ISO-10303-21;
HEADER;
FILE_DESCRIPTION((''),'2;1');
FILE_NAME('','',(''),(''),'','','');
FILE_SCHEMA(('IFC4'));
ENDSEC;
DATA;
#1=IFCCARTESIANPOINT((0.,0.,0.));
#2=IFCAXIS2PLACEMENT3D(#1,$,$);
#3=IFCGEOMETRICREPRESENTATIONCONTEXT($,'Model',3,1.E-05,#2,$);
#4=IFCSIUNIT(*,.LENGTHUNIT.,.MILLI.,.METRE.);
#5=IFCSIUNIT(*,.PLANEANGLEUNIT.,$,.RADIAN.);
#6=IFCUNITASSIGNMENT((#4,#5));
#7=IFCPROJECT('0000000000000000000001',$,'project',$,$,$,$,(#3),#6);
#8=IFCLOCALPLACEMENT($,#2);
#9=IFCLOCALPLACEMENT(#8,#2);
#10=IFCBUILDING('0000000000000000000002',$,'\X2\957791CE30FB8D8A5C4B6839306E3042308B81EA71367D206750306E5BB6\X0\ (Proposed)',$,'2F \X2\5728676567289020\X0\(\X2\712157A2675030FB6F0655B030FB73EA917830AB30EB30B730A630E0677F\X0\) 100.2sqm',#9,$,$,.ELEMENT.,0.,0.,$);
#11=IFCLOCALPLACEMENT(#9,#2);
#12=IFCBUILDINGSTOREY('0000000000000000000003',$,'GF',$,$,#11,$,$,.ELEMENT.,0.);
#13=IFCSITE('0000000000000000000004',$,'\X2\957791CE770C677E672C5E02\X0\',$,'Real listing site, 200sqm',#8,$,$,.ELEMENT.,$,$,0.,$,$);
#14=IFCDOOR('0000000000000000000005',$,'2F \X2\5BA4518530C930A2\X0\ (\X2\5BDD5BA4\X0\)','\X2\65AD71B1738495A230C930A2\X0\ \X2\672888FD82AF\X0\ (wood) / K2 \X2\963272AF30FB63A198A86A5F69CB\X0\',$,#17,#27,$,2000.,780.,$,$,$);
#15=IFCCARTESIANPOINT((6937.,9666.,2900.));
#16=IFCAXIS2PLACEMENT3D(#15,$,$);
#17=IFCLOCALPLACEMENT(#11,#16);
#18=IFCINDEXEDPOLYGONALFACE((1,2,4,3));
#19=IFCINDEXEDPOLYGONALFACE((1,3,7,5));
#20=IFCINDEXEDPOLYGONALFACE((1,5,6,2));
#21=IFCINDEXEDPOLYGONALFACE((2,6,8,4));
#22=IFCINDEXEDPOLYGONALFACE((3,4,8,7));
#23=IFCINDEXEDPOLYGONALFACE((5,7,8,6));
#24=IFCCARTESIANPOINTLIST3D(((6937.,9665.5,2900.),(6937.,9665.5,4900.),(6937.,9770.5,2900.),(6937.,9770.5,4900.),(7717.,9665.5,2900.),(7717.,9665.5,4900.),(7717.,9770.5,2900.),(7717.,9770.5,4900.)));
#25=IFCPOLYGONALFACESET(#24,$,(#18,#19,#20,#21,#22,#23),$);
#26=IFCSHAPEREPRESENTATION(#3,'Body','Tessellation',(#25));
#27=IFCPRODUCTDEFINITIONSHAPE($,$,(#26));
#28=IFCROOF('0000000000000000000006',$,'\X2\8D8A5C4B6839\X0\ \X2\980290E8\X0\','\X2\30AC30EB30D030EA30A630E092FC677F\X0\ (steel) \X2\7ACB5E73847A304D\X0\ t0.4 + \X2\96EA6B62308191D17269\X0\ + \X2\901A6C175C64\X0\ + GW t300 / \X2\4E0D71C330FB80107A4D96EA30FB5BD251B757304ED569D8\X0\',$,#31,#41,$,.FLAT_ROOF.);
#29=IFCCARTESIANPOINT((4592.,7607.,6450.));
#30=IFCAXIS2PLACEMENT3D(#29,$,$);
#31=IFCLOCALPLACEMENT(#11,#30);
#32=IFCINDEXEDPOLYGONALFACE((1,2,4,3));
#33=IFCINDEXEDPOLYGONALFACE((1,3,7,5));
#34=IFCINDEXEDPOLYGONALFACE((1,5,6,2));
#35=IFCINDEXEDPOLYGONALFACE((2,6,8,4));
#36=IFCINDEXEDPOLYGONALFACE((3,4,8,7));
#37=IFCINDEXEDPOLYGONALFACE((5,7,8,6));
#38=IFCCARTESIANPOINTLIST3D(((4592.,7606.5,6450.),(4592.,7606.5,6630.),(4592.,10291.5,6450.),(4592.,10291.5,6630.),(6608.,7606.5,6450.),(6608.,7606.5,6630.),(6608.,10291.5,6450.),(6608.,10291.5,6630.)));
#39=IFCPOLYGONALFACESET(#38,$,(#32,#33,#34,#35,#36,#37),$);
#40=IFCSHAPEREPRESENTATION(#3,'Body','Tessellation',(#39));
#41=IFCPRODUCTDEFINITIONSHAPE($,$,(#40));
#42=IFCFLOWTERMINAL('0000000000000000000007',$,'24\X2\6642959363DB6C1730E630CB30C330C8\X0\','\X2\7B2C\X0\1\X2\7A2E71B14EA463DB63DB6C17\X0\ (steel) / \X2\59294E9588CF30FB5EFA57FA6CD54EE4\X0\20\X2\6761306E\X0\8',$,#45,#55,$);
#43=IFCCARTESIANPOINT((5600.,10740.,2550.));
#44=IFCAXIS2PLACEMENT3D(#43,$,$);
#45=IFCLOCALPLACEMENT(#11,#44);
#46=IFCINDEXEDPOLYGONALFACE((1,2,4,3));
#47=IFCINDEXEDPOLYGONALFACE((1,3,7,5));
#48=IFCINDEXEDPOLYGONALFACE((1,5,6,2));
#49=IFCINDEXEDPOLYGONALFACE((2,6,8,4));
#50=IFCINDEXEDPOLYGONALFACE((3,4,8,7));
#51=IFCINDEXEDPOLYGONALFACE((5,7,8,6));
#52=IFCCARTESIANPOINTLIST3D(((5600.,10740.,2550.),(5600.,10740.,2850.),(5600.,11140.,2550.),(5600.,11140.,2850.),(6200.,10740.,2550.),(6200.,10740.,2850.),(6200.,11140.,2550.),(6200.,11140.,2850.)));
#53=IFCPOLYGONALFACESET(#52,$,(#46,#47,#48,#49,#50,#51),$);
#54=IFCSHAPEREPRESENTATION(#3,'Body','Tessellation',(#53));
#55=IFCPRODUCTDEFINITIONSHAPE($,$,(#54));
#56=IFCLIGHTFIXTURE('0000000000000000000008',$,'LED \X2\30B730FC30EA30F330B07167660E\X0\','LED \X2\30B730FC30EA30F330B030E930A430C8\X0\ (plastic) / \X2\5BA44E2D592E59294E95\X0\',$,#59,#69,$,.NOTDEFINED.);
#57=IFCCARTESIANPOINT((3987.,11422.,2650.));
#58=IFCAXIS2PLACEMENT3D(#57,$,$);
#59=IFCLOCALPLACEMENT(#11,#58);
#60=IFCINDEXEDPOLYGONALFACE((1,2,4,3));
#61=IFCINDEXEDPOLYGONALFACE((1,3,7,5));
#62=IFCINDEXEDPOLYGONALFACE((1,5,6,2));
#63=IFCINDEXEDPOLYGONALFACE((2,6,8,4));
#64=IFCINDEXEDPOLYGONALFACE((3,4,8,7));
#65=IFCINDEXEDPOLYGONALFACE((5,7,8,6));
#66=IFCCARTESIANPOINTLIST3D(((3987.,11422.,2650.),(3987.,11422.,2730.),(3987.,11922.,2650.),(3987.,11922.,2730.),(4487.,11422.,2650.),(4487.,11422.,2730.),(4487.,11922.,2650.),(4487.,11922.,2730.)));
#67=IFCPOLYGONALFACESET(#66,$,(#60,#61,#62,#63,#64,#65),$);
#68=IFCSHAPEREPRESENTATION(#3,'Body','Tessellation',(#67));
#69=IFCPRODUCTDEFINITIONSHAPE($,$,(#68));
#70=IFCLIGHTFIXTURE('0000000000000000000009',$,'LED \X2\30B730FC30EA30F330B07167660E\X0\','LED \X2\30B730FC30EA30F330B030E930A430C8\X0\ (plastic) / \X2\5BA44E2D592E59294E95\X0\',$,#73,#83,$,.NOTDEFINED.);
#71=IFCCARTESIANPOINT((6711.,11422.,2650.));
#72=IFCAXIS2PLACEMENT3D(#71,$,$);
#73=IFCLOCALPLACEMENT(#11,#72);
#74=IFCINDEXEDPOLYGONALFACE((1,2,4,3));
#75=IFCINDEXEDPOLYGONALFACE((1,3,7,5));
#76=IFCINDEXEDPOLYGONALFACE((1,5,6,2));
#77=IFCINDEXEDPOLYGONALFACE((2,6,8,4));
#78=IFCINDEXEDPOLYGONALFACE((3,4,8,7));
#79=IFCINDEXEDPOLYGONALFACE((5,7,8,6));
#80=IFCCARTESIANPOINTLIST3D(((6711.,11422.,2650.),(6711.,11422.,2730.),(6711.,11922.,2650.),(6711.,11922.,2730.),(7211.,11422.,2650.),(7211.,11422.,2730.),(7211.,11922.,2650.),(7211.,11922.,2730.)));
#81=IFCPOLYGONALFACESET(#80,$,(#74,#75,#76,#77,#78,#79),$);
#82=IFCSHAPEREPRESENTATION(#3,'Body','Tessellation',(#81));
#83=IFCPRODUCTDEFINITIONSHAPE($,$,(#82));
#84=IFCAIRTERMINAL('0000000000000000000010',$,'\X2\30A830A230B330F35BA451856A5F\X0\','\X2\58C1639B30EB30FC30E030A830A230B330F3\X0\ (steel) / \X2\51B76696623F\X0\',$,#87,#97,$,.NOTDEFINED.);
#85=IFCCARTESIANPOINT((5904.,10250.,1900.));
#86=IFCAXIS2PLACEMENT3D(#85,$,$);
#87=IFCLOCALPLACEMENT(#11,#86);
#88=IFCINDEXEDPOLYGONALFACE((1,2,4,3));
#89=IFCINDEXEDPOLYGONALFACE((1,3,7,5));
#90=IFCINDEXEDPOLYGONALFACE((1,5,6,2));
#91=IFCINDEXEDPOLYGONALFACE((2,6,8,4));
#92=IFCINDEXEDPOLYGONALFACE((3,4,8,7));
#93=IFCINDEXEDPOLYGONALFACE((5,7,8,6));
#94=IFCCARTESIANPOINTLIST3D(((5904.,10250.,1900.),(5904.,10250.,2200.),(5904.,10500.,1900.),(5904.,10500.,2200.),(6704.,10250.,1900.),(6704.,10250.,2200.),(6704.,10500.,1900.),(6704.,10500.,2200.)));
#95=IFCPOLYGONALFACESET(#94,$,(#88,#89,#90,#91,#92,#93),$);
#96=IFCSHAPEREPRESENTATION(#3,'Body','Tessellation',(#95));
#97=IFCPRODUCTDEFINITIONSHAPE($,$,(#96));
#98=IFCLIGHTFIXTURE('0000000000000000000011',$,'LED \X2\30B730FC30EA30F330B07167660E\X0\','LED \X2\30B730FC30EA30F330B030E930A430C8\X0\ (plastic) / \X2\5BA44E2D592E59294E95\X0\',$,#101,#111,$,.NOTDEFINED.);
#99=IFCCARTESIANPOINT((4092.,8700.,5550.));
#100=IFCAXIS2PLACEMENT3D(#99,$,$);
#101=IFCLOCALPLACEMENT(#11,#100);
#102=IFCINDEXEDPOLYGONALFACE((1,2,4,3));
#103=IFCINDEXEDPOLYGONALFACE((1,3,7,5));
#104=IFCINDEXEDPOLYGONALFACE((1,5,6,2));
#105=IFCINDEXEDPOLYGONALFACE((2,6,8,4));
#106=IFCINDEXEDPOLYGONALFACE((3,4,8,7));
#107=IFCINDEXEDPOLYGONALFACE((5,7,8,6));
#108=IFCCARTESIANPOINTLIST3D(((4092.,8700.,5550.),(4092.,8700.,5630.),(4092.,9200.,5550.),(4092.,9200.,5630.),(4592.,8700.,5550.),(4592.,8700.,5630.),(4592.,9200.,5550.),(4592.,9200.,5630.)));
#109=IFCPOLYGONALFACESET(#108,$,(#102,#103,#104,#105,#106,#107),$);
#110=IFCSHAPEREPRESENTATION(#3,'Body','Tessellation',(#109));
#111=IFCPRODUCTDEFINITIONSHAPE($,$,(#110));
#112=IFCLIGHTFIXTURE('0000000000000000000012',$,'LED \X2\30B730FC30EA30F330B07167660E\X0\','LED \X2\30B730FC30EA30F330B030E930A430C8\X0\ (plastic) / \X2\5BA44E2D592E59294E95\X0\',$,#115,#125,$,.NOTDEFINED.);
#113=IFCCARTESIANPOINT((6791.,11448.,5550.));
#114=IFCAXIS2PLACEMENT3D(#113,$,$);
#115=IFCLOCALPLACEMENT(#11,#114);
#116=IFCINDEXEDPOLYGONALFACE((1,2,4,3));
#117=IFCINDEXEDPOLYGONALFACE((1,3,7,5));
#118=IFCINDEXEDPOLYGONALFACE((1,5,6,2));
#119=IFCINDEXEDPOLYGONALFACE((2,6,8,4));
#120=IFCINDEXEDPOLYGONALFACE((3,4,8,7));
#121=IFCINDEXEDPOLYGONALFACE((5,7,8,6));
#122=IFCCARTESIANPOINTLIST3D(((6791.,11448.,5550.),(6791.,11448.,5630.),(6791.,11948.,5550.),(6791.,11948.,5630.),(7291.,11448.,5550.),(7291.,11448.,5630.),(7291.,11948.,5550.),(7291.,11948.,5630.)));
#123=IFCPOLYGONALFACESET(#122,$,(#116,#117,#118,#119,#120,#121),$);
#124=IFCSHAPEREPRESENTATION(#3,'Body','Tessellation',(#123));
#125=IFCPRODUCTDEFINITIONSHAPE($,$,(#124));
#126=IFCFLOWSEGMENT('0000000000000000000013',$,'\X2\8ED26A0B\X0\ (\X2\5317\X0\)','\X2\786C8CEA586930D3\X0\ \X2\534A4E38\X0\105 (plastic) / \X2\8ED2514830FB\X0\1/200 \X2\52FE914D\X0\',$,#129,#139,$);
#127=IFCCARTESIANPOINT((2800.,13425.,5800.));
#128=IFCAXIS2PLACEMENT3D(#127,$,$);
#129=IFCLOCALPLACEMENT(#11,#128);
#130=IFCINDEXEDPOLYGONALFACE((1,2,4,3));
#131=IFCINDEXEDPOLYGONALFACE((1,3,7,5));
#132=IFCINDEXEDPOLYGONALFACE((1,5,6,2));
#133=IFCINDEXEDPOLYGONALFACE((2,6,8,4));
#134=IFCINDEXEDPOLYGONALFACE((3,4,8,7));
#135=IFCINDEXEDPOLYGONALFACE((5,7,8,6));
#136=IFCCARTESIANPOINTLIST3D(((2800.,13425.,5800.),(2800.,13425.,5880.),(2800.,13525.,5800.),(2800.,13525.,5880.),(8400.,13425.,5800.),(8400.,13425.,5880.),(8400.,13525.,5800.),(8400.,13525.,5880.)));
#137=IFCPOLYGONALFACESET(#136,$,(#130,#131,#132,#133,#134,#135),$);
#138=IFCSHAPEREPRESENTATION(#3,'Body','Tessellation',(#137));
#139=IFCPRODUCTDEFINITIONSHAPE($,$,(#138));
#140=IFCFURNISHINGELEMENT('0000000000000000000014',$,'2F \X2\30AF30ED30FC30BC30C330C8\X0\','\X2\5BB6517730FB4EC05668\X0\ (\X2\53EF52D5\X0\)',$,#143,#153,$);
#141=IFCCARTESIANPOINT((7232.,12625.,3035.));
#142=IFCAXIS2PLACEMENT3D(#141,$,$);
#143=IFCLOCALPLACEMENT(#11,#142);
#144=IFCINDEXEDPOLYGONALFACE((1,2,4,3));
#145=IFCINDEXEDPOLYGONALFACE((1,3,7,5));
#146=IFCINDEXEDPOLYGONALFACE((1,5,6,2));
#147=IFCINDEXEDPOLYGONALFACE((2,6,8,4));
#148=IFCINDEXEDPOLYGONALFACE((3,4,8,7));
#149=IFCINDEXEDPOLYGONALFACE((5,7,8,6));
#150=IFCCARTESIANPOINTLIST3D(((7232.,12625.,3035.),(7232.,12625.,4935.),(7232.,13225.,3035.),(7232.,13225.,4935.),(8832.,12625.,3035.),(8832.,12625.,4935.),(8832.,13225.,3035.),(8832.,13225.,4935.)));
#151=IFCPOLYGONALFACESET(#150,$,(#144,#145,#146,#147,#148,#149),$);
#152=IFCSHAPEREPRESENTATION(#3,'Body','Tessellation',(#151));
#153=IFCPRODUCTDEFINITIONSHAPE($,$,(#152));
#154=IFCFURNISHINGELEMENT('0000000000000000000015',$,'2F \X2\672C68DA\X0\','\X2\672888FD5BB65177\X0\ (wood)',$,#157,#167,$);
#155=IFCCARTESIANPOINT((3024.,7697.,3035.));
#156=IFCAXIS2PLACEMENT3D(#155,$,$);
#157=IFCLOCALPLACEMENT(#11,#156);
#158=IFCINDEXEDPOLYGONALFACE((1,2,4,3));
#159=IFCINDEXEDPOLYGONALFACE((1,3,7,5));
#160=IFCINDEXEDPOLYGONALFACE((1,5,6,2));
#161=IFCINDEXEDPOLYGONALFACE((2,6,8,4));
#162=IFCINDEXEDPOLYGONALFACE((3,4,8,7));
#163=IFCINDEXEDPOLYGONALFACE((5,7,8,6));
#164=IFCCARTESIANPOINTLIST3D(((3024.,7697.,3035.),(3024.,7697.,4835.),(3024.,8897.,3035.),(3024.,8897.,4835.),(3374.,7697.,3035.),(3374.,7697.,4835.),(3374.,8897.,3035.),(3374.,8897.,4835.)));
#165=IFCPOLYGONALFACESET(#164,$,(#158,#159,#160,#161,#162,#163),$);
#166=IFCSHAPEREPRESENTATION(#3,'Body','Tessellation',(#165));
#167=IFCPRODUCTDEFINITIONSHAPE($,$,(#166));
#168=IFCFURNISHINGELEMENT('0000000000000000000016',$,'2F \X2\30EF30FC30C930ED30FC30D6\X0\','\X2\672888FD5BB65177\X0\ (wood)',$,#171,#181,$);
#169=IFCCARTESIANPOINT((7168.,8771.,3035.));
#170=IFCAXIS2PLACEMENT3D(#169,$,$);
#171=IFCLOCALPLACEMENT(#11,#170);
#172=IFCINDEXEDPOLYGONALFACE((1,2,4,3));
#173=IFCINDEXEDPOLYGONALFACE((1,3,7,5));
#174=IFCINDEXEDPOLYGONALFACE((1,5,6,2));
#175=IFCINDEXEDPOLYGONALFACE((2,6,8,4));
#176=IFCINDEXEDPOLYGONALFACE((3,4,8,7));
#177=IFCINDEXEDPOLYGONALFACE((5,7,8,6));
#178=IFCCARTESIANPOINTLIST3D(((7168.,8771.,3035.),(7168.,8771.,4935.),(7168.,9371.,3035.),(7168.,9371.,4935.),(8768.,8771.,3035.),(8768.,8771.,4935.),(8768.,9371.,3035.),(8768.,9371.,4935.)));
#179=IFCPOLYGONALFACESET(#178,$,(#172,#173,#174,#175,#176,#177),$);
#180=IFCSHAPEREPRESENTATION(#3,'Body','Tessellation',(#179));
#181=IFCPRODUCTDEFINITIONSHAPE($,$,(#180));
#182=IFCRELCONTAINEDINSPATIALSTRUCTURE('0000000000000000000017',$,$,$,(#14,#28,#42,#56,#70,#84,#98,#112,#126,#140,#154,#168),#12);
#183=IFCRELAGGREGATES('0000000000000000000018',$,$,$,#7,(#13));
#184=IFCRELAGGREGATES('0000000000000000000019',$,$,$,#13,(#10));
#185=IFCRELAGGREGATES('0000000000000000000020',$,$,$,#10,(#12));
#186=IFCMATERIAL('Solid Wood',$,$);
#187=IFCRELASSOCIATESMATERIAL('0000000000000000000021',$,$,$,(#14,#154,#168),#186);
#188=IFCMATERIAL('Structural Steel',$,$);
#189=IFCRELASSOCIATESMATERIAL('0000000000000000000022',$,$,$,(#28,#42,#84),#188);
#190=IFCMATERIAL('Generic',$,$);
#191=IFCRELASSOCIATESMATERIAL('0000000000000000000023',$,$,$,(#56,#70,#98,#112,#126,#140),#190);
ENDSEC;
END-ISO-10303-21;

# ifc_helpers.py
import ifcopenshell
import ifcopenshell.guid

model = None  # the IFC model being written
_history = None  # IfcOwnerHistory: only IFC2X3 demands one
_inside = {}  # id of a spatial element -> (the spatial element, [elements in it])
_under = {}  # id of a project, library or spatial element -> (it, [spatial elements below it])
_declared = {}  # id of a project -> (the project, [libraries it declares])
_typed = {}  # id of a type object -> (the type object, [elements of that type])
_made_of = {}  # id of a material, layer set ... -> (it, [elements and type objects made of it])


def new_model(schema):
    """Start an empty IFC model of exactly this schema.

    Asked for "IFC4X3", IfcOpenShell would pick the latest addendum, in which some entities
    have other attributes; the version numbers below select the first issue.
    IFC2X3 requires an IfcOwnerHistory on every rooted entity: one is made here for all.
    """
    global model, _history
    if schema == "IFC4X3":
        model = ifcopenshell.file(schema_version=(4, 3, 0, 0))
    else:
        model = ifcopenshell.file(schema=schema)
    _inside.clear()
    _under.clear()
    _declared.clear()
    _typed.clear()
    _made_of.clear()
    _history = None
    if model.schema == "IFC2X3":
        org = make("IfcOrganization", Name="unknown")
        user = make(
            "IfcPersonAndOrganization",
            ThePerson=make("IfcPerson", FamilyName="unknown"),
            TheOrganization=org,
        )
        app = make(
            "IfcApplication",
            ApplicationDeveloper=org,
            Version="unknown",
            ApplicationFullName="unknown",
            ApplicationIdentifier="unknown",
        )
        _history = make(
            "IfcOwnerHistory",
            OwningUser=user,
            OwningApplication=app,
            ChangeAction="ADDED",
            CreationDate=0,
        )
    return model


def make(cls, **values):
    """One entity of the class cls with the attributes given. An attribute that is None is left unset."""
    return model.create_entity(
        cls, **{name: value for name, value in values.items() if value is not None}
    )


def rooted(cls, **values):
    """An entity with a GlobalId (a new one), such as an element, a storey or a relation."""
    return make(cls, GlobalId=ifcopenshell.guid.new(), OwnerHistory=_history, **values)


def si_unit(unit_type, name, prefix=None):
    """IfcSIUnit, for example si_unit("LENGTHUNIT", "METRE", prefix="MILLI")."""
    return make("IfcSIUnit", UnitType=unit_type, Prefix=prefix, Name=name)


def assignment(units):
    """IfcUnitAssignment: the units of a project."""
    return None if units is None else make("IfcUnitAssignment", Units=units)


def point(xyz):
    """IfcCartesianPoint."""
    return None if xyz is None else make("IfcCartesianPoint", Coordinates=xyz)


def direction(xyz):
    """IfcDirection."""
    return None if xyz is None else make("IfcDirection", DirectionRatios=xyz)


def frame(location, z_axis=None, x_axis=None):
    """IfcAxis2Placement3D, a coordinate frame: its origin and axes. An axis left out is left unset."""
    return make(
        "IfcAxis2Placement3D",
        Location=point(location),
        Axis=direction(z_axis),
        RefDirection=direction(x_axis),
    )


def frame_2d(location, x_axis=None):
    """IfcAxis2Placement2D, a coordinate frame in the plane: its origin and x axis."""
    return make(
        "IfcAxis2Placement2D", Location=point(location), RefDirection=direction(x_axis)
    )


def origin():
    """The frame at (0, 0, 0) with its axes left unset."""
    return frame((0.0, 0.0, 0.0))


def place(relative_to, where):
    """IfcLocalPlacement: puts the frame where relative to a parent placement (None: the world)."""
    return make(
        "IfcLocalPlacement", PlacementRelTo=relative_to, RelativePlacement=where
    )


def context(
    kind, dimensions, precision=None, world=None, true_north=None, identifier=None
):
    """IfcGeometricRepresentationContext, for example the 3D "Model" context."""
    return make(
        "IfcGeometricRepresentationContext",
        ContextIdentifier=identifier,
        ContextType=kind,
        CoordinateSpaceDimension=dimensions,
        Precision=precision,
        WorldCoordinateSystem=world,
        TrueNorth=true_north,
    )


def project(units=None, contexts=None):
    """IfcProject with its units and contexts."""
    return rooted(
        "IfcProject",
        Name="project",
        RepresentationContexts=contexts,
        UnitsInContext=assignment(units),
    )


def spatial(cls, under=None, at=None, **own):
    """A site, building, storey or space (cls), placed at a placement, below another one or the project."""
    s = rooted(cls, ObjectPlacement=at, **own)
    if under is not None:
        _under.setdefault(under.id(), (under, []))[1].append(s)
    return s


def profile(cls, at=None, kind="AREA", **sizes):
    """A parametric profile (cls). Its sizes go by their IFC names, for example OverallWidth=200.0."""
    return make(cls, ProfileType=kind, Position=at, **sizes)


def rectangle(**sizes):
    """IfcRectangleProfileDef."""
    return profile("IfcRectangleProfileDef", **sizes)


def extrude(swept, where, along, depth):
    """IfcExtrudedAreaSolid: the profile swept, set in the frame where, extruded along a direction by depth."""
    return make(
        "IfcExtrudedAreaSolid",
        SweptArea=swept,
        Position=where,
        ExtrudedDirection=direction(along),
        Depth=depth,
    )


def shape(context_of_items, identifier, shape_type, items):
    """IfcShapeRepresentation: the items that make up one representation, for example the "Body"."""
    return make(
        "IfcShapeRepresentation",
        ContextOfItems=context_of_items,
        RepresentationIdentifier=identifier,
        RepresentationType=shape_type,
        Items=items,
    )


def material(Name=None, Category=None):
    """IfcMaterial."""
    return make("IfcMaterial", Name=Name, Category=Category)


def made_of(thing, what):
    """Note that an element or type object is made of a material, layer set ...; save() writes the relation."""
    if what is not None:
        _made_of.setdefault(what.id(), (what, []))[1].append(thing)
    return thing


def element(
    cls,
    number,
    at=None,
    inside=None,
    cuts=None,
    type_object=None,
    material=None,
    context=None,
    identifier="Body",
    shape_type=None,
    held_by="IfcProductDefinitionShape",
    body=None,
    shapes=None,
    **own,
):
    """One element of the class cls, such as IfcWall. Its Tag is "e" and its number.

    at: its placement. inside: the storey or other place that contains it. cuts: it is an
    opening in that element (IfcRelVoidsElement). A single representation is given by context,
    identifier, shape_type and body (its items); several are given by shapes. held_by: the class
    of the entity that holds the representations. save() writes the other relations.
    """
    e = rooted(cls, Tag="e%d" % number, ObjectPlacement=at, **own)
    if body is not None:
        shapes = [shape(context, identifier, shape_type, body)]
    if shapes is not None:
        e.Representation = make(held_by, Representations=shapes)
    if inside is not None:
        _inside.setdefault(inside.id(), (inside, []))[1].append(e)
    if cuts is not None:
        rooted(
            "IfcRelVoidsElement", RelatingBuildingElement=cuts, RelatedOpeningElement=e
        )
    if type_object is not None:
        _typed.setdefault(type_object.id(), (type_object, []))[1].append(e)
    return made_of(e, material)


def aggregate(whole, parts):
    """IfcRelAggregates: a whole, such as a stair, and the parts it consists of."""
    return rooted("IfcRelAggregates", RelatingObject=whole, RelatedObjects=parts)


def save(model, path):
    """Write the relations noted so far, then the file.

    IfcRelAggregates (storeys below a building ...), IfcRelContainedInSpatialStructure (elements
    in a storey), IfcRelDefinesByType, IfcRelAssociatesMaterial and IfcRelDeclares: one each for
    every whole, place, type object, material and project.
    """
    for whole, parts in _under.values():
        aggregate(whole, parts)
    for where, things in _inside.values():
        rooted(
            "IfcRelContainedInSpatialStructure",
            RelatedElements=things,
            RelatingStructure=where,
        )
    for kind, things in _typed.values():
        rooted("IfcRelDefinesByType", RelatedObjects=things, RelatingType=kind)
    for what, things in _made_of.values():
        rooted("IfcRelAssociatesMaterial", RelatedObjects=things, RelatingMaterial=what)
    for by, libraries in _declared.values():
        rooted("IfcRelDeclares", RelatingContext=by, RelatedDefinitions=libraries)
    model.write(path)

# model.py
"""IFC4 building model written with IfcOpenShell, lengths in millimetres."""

from ifc_helpers import new_model, si_unit, frame, frame_2d, origin, place, context, project, spatial, rectangle, extrude, material, element, save


model = new_model("IFC4")

# Units and contexts
model_context = context("Model", 3, precision=1e-05, world=origin())
ifc_project = project(units=[si_unit("LENGTHUNIT", "METRE", prefix="MILLI"), si_unit("PLANEANGLEUNIT", "RADIAN")], contexts=[model_context])

# Site, building, storey
site_placement = place(None, origin())
site = spatial("IfcSite", under=ifc_project, at=site_placement, Name="長野県松本市", ObjectType="Real listing site, 200sqm", CompositionType="ELEMENT", RefElevation=0.0)
building_placement = place(site_placement, origin())
building = spatial("IfcBuilding", under=site, at=building_placement, Name="長野・越屋根のある自然素材の家 (Proposed)", ObjectType="2F 在来木造(無垢材・漆喰・珪酸カルシウム板) 100.2sqm", CompositionType="ELEMENT", ElevationOfRefHeight=0.0, ElevationOfTerrain=0.0)
storey_placement = place(building_placement, origin())
storey = spatial("IfcBuildingStorey", under=building, at=storey_placement, Name="GF", CompositionType="ELEMENT", Elevation=0.0)

# Shared definitions
ifc_material_1 = material(Name="Solid Wood")

# Door
door_placement = place(storey_placement, frame((6937.0, 9666.0, 2900.0)))
element("IfcDoor", 1, at=door_placement, inside=storey, material=ifc_material_1, Name="2F 室内ドア (寝室)", Description="断熱玄関ドア 木製芯 (wood) / K2 防犯・採風機構", OverallHeight=2000.0, OverallWidth=780.0, context=model_context, shape_type="SweptSolid", body=[
    extrude(rectangle(XDim=780.0, YDim=105.0, at=frame_2d((390.0, 52.0))), frame((6937.0, 9666.0, 2900.0)), (0.0, 0.0, 1.0), 2000.0),
])

# Roof
ifc_material_2 = material(Name="Structural Steel")
roof_placement = place(storey_placement, frame((4592.0, 7607.0, 6450.0)))
element("IfcRoof", 2, at=roof_placement, inside=storey, material=ifc_material_2, Name="越屋根 頂部", Description="ガルバリウム鋼板 (steel) 立平葺き t0.4 + 雪止め金物 + 通気層 + GW t300 / 不燃・耐積雪・寒冷地仕様", PredefinedType="FLAT_ROOF", context=model_context, shape_type="SweptSolid", body=[
    extrude(rectangle(XDim=2016.0, YDim=2685.0, at=frame_2d((1008.0, 1342.0))), frame((4592.0, 7607.0, 6450.0)), (0.0, 0.0, 1.0), 180.0),
])

# Flow terminal
flow_terminal_placement = place(storey_placement, frame((5600.0, 10740.0, 2550.0)))
element("IfcFlowTerminal", 3, at=flow_terminal_placement, inside=storey, material=ifc_material_2, Name="24時間換気ユニット", Description="第1種熱交換換気 (steel) / 天井裏・建基法令20条の8", context=model_context, shape_type="SweptSolid", body=[
    extrude(rectangle(XDim=600.0, YDim=400.0, at=frame_2d((300.0, 200.0))), frame((5600.0, 10740.0, 2550.0)), (0.0, 0.0, 1.0), 300.0),
])

# Light fixtures
ifc_material_3 = material(Name="Generic")
light_fixture_1_placement = place(storey_placement, frame((3987.0, 11422.0, 2650.0)))
element("IfcLightFixture", 4, at=light_fixture_1_placement, inside=storey, material=ifc_material_3, Name="LED シーリング照明", Description="LED シーリングライト (plastic) / 室中央天井", PredefinedType="NOTDEFINED", context=model_context, shape_type="SweptSolid", body=[
    extrude(rectangle(XDim=500.0, YDim=500.0, at=frame_2d((250.0, 250.0))), frame((3987.0, 11422.0, 2650.0)), (0.0, 0.0, 1.0), 80.0),
])
light_fixture_2_placement = place(storey_placement, frame((6711.0, 11422.0, 2650.0)))
element("IfcLightFixture", 5, at=light_fixture_2_placement, inside=storey, material=ifc_material_3, Name="LED シーリング照明", Description="LED シーリングライト (plastic) / 室中央天井", PredefinedType="NOTDEFINED", context=model_context, shape_type="SweptSolid", body=[
    extrude(rectangle(XDim=500.0, YDim=500.0, at=frame_2d((250.0, 250.0))), frame((6711.0, 11422.0, 2650.0)), (0.0, 0.0, 1.0), 80.0),
])

# Air terminal
air_terminal_placement = place(storey_placement, frame((5904.0, 10250.0, 1900.0)))
element("IfcAirTerminal", 6, at=air_terminal_placement, inside=storey, material=ifc_material_2, Name="エアコン室内機", Description="壁掛ルームエアコン (steel) / 冷暖房", PredefinedType="NOTDEFINED", context=model_context, shape_type="SweptSolid", body=[
    extrude(rectangle(XDim=800.0, YDim=250.0, at=frame_2d((400.0, 125.0))), frame((5904.0, 10250.0, 1900.0)), (0.0, 0.0, 1.0), 300.0),
])

# Light fixtures
light_fixture_3_placement = place(storey_placement, frame((4092.0, 8700.0, 5550.0)))
element("IfcLightFixture", 7, at=light_fixture_3_placement, inside=storey, material=ifc_material_3, Name="LED シーリング照明", Description="LED シーリングライト (plastic) / 室中央天井", PredefinedType="NOTDEFINED", context=model_context, shape_type="SweptSolid", body=[
    extrude(rectangle(XDim=500.0, YDim=500.0, at=frame_2d((250.0, 250.0))), frame((4092.0, 8700.0, 5550.0)), (0.0, 0.0, 1.0), 80.0),
])
light_fixture_4_placement = place(storey_placement, frame((6791.0, 11448.0, 5550.0)))
element("IfcLightFixture", 8, at=light_fixture_4_placement, inside=storey, material=ifc_material_3, Name="LED シーリング照明", Description="LED シーリングライト (plastic) / 室中央天井", PredefinedType="NOTDEFINED", context=model_context, shape_type="SweptSolid", body=[
    extrude(rectangle(XDim=500.0, YDim=500.0, at=frame_2d((250.0, 250.0))), frame((6791.0, 11448.0, 5550.0)), (0.0, 0.0, 1.0), 80.0),
])

# Flow segment
flow_segment_placement = place(storey_placement, frame((2800.0, 13425.0, 5800.0)))
element("IfcFlowSegment", 9, at=flow_segment_placement, inside=storey, material=ifc_material_3, Name="軒樋 (北)", Description="硬質塩ビ 半丸105 (plastic) / 軒先・1/200 勾配", context=model_context, shape_type="SweptSolid", body=[
    extrude(rectangle(XDim=5600.0, YDim=100.0, at=frame_2d((2800.0, 50.0))), frame((2800.0, 13425.0, 5800.0)), (0.0, 0.0, 1.0), 80.0),
])

# Furnishing elements
furnishing_1_placement = place(storey_placement, frame((7232.0, 12625.0, 3035.0)))
element("IfcFurnishingElement", 10, at=furnishing_1_placement, inside=storey, material=ifc_material_3, Name="2F クローゼット", Description="家具・什器 (可動)", context=model_context, shape_type="SweptSolid", body=[
    extrude(rectangle(XDim=1600.0, YDim=600.0, at=frame_2d((800.0, 300.0))), frame((7232.0, 12625.0, 3035.0)), (0.0, 0.0, 1.0), 1900.0),
])
furnishing_2_placement = place(storey_placement, frame((3024.0, 7697.0, 3035.0)))
element("IfcFurnishingElement", 11, at=furnishing_2_placement, inside=storey, material=ifc_material_1, Name="2F 本棚", Description="木製家具 (wood)", context=model_context, shape_type="SweptSolid", body=[
    extrude(rectangle(XDim=350.0, YDim=1200.0, at=frame_2d((175.0, 600.0))), frame((3024.0, 7697.0, 3035.0)), (0.0, 0.0, 1.0), 1800.0),
])
furnishing_3_placement = place(storey_placement, frame((7168.0, 8771.0, 3035.0)))
element("IfcFurnishingElement", 12, at=furnishing_3_placement, inside=storey, material=ifc_material_1, Name="2F ワードローブ", Description="木製家具 (wood)", context=model_context, shape_type="SweptSolid", body=[
    extrude(rectangle(XDim=1600.0, YDim=600.0, at=frame_2d((800.0, 300.0))), frame((7168.0, 8771.0, 3035.0)), (0.0, 0.0, 1.0), 1900.0),
])

save(model, "model.ifc")
